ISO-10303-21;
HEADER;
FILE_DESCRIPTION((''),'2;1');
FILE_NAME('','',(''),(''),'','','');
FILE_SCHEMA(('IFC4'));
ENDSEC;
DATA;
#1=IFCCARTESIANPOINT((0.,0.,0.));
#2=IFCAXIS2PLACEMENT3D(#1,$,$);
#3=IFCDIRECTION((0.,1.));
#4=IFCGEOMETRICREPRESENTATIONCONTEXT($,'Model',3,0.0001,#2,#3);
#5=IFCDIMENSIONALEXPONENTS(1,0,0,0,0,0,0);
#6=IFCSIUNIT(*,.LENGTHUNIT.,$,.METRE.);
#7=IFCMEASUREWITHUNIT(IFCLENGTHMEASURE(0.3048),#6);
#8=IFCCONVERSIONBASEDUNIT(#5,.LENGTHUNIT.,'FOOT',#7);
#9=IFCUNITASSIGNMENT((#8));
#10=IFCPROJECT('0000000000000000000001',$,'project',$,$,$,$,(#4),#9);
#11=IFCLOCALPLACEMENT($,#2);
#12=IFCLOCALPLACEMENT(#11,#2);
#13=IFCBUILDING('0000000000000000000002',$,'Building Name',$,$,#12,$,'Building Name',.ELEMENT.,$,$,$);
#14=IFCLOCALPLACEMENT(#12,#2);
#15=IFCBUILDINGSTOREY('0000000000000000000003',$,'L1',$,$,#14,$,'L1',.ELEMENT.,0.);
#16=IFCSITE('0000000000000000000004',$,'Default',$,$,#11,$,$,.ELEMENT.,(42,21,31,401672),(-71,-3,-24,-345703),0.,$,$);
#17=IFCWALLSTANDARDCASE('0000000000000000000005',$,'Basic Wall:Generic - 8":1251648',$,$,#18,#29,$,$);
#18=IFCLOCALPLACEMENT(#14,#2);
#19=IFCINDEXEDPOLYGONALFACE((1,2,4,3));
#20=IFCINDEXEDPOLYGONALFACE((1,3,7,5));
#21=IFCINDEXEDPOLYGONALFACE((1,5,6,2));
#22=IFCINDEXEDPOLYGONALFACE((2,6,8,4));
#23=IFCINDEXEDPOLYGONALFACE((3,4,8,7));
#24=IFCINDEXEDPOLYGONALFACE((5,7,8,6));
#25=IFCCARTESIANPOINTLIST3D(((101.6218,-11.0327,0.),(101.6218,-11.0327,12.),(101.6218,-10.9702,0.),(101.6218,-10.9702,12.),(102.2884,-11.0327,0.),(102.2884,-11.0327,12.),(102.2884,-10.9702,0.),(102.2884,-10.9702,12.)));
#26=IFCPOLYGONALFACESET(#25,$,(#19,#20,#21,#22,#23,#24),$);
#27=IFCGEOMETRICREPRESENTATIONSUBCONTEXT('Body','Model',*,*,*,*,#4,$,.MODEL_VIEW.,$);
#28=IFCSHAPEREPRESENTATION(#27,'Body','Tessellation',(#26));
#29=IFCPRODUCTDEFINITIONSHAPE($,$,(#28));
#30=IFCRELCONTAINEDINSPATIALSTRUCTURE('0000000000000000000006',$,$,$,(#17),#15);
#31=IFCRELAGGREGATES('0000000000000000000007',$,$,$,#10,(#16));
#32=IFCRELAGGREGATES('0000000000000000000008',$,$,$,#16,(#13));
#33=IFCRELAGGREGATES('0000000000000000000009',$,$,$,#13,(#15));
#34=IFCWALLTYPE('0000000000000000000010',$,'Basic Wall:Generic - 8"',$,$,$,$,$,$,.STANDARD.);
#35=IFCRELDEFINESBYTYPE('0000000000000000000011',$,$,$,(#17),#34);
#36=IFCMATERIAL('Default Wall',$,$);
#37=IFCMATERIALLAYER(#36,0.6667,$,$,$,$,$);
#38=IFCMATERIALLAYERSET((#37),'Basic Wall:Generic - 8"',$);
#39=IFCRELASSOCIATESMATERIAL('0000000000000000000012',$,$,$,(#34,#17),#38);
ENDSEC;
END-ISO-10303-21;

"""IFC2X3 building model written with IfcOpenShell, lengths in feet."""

from ifc_helpers import new_model, entity, si_unit, converted_unit, direction, frame, frame_2d, origin, place, context, subcontext, project, spatial, rectangle, extrude, material, layer, layer_set, layer_usage, type_object, element, save


model = new_model("IFC2X3")

# Units and contexts
model_context = context("Model", 3, precision=0.0001, world=origin(), true_north=direction((0.0, 1.0)))
body_context = subcontext(model_context, "Body", "Model", "MODEL_VIEW")
ifc_project = project(units=[converted_unit("LENGTHUNIT", "FOOT", entity("IfcLengthMeasure", 0.3048), si_unit("LENGTHUNIT", "METRE"), dimensions=[1, 0, 0, 0, 0, 0, 0])], contexts=[model_context])

# Site, building, storey
site_placement = place(None, origin())
site = spatial("IfcSite", under=ifc_project, at=site_placement, Name="Default", CompositionType="ELEMENT", RefLatitude=(42, 21, 31, 401672), RefLongitude=(-71, -3, -24, -345703), RefElevation=0.0)
building_placement = place(site_placement, origin())
building = spatial("IfcBuilding", under=site, at=building_placement, Name="Building Name", LongName="Building Name", CompositionType="ELEMENT")
storey_placement = place(building_placement, origin())
storey = spatial("IfcBuildingStorey", under=building, at=storey_placement, Name="L1", LongName="L1", CompositionType="ELEMENT", Elevation=0.0)

# Wall
ifc_material_1 = material(Name="Default Wall")
ifc_layer_1 = layer(ifc_material_1, 0.6667)
ifc_layer_set_1 = layer_set([ifc_layer_1], Name="Basic Wall:Generic - 8\"")
wall_type_1 = type_object("IfcWallType", Name="Basic Wall:Generic - 8\"", PredefinedType="STANDARD", material=ifc_layer_set_1)
ifc_layer_usage_1 = layer_usage(ifc_layer_set_1, "AXIS2", "NEGATIVE", 0.3333)
wall_1_placement = place(storey_placement, frame((101.9551, -10.9702, 0.0), z_axis=(0.0, 0.0, 1.0), x_axis=(0.0, -1.0, 0.0)))
element("IfcWallStandardCase", 1, at=wall_1_placement, inside=storey, type_object=wall_type_1, material=ifc_layer_usage_1, Name="Basic Wall:Generic - 8\":1251648", context=body_context, shape_type="SweptSolid", body=[
    extrude(rectangle(XDim=0.0625, YDim=0.6667, at=frame_2d((0.0312, 0.0), x_axis=(-1.0, 0.0))), origin(), (0.0, 0.0, 1.0), 12.0),
])

save(model, "model.ifc")
